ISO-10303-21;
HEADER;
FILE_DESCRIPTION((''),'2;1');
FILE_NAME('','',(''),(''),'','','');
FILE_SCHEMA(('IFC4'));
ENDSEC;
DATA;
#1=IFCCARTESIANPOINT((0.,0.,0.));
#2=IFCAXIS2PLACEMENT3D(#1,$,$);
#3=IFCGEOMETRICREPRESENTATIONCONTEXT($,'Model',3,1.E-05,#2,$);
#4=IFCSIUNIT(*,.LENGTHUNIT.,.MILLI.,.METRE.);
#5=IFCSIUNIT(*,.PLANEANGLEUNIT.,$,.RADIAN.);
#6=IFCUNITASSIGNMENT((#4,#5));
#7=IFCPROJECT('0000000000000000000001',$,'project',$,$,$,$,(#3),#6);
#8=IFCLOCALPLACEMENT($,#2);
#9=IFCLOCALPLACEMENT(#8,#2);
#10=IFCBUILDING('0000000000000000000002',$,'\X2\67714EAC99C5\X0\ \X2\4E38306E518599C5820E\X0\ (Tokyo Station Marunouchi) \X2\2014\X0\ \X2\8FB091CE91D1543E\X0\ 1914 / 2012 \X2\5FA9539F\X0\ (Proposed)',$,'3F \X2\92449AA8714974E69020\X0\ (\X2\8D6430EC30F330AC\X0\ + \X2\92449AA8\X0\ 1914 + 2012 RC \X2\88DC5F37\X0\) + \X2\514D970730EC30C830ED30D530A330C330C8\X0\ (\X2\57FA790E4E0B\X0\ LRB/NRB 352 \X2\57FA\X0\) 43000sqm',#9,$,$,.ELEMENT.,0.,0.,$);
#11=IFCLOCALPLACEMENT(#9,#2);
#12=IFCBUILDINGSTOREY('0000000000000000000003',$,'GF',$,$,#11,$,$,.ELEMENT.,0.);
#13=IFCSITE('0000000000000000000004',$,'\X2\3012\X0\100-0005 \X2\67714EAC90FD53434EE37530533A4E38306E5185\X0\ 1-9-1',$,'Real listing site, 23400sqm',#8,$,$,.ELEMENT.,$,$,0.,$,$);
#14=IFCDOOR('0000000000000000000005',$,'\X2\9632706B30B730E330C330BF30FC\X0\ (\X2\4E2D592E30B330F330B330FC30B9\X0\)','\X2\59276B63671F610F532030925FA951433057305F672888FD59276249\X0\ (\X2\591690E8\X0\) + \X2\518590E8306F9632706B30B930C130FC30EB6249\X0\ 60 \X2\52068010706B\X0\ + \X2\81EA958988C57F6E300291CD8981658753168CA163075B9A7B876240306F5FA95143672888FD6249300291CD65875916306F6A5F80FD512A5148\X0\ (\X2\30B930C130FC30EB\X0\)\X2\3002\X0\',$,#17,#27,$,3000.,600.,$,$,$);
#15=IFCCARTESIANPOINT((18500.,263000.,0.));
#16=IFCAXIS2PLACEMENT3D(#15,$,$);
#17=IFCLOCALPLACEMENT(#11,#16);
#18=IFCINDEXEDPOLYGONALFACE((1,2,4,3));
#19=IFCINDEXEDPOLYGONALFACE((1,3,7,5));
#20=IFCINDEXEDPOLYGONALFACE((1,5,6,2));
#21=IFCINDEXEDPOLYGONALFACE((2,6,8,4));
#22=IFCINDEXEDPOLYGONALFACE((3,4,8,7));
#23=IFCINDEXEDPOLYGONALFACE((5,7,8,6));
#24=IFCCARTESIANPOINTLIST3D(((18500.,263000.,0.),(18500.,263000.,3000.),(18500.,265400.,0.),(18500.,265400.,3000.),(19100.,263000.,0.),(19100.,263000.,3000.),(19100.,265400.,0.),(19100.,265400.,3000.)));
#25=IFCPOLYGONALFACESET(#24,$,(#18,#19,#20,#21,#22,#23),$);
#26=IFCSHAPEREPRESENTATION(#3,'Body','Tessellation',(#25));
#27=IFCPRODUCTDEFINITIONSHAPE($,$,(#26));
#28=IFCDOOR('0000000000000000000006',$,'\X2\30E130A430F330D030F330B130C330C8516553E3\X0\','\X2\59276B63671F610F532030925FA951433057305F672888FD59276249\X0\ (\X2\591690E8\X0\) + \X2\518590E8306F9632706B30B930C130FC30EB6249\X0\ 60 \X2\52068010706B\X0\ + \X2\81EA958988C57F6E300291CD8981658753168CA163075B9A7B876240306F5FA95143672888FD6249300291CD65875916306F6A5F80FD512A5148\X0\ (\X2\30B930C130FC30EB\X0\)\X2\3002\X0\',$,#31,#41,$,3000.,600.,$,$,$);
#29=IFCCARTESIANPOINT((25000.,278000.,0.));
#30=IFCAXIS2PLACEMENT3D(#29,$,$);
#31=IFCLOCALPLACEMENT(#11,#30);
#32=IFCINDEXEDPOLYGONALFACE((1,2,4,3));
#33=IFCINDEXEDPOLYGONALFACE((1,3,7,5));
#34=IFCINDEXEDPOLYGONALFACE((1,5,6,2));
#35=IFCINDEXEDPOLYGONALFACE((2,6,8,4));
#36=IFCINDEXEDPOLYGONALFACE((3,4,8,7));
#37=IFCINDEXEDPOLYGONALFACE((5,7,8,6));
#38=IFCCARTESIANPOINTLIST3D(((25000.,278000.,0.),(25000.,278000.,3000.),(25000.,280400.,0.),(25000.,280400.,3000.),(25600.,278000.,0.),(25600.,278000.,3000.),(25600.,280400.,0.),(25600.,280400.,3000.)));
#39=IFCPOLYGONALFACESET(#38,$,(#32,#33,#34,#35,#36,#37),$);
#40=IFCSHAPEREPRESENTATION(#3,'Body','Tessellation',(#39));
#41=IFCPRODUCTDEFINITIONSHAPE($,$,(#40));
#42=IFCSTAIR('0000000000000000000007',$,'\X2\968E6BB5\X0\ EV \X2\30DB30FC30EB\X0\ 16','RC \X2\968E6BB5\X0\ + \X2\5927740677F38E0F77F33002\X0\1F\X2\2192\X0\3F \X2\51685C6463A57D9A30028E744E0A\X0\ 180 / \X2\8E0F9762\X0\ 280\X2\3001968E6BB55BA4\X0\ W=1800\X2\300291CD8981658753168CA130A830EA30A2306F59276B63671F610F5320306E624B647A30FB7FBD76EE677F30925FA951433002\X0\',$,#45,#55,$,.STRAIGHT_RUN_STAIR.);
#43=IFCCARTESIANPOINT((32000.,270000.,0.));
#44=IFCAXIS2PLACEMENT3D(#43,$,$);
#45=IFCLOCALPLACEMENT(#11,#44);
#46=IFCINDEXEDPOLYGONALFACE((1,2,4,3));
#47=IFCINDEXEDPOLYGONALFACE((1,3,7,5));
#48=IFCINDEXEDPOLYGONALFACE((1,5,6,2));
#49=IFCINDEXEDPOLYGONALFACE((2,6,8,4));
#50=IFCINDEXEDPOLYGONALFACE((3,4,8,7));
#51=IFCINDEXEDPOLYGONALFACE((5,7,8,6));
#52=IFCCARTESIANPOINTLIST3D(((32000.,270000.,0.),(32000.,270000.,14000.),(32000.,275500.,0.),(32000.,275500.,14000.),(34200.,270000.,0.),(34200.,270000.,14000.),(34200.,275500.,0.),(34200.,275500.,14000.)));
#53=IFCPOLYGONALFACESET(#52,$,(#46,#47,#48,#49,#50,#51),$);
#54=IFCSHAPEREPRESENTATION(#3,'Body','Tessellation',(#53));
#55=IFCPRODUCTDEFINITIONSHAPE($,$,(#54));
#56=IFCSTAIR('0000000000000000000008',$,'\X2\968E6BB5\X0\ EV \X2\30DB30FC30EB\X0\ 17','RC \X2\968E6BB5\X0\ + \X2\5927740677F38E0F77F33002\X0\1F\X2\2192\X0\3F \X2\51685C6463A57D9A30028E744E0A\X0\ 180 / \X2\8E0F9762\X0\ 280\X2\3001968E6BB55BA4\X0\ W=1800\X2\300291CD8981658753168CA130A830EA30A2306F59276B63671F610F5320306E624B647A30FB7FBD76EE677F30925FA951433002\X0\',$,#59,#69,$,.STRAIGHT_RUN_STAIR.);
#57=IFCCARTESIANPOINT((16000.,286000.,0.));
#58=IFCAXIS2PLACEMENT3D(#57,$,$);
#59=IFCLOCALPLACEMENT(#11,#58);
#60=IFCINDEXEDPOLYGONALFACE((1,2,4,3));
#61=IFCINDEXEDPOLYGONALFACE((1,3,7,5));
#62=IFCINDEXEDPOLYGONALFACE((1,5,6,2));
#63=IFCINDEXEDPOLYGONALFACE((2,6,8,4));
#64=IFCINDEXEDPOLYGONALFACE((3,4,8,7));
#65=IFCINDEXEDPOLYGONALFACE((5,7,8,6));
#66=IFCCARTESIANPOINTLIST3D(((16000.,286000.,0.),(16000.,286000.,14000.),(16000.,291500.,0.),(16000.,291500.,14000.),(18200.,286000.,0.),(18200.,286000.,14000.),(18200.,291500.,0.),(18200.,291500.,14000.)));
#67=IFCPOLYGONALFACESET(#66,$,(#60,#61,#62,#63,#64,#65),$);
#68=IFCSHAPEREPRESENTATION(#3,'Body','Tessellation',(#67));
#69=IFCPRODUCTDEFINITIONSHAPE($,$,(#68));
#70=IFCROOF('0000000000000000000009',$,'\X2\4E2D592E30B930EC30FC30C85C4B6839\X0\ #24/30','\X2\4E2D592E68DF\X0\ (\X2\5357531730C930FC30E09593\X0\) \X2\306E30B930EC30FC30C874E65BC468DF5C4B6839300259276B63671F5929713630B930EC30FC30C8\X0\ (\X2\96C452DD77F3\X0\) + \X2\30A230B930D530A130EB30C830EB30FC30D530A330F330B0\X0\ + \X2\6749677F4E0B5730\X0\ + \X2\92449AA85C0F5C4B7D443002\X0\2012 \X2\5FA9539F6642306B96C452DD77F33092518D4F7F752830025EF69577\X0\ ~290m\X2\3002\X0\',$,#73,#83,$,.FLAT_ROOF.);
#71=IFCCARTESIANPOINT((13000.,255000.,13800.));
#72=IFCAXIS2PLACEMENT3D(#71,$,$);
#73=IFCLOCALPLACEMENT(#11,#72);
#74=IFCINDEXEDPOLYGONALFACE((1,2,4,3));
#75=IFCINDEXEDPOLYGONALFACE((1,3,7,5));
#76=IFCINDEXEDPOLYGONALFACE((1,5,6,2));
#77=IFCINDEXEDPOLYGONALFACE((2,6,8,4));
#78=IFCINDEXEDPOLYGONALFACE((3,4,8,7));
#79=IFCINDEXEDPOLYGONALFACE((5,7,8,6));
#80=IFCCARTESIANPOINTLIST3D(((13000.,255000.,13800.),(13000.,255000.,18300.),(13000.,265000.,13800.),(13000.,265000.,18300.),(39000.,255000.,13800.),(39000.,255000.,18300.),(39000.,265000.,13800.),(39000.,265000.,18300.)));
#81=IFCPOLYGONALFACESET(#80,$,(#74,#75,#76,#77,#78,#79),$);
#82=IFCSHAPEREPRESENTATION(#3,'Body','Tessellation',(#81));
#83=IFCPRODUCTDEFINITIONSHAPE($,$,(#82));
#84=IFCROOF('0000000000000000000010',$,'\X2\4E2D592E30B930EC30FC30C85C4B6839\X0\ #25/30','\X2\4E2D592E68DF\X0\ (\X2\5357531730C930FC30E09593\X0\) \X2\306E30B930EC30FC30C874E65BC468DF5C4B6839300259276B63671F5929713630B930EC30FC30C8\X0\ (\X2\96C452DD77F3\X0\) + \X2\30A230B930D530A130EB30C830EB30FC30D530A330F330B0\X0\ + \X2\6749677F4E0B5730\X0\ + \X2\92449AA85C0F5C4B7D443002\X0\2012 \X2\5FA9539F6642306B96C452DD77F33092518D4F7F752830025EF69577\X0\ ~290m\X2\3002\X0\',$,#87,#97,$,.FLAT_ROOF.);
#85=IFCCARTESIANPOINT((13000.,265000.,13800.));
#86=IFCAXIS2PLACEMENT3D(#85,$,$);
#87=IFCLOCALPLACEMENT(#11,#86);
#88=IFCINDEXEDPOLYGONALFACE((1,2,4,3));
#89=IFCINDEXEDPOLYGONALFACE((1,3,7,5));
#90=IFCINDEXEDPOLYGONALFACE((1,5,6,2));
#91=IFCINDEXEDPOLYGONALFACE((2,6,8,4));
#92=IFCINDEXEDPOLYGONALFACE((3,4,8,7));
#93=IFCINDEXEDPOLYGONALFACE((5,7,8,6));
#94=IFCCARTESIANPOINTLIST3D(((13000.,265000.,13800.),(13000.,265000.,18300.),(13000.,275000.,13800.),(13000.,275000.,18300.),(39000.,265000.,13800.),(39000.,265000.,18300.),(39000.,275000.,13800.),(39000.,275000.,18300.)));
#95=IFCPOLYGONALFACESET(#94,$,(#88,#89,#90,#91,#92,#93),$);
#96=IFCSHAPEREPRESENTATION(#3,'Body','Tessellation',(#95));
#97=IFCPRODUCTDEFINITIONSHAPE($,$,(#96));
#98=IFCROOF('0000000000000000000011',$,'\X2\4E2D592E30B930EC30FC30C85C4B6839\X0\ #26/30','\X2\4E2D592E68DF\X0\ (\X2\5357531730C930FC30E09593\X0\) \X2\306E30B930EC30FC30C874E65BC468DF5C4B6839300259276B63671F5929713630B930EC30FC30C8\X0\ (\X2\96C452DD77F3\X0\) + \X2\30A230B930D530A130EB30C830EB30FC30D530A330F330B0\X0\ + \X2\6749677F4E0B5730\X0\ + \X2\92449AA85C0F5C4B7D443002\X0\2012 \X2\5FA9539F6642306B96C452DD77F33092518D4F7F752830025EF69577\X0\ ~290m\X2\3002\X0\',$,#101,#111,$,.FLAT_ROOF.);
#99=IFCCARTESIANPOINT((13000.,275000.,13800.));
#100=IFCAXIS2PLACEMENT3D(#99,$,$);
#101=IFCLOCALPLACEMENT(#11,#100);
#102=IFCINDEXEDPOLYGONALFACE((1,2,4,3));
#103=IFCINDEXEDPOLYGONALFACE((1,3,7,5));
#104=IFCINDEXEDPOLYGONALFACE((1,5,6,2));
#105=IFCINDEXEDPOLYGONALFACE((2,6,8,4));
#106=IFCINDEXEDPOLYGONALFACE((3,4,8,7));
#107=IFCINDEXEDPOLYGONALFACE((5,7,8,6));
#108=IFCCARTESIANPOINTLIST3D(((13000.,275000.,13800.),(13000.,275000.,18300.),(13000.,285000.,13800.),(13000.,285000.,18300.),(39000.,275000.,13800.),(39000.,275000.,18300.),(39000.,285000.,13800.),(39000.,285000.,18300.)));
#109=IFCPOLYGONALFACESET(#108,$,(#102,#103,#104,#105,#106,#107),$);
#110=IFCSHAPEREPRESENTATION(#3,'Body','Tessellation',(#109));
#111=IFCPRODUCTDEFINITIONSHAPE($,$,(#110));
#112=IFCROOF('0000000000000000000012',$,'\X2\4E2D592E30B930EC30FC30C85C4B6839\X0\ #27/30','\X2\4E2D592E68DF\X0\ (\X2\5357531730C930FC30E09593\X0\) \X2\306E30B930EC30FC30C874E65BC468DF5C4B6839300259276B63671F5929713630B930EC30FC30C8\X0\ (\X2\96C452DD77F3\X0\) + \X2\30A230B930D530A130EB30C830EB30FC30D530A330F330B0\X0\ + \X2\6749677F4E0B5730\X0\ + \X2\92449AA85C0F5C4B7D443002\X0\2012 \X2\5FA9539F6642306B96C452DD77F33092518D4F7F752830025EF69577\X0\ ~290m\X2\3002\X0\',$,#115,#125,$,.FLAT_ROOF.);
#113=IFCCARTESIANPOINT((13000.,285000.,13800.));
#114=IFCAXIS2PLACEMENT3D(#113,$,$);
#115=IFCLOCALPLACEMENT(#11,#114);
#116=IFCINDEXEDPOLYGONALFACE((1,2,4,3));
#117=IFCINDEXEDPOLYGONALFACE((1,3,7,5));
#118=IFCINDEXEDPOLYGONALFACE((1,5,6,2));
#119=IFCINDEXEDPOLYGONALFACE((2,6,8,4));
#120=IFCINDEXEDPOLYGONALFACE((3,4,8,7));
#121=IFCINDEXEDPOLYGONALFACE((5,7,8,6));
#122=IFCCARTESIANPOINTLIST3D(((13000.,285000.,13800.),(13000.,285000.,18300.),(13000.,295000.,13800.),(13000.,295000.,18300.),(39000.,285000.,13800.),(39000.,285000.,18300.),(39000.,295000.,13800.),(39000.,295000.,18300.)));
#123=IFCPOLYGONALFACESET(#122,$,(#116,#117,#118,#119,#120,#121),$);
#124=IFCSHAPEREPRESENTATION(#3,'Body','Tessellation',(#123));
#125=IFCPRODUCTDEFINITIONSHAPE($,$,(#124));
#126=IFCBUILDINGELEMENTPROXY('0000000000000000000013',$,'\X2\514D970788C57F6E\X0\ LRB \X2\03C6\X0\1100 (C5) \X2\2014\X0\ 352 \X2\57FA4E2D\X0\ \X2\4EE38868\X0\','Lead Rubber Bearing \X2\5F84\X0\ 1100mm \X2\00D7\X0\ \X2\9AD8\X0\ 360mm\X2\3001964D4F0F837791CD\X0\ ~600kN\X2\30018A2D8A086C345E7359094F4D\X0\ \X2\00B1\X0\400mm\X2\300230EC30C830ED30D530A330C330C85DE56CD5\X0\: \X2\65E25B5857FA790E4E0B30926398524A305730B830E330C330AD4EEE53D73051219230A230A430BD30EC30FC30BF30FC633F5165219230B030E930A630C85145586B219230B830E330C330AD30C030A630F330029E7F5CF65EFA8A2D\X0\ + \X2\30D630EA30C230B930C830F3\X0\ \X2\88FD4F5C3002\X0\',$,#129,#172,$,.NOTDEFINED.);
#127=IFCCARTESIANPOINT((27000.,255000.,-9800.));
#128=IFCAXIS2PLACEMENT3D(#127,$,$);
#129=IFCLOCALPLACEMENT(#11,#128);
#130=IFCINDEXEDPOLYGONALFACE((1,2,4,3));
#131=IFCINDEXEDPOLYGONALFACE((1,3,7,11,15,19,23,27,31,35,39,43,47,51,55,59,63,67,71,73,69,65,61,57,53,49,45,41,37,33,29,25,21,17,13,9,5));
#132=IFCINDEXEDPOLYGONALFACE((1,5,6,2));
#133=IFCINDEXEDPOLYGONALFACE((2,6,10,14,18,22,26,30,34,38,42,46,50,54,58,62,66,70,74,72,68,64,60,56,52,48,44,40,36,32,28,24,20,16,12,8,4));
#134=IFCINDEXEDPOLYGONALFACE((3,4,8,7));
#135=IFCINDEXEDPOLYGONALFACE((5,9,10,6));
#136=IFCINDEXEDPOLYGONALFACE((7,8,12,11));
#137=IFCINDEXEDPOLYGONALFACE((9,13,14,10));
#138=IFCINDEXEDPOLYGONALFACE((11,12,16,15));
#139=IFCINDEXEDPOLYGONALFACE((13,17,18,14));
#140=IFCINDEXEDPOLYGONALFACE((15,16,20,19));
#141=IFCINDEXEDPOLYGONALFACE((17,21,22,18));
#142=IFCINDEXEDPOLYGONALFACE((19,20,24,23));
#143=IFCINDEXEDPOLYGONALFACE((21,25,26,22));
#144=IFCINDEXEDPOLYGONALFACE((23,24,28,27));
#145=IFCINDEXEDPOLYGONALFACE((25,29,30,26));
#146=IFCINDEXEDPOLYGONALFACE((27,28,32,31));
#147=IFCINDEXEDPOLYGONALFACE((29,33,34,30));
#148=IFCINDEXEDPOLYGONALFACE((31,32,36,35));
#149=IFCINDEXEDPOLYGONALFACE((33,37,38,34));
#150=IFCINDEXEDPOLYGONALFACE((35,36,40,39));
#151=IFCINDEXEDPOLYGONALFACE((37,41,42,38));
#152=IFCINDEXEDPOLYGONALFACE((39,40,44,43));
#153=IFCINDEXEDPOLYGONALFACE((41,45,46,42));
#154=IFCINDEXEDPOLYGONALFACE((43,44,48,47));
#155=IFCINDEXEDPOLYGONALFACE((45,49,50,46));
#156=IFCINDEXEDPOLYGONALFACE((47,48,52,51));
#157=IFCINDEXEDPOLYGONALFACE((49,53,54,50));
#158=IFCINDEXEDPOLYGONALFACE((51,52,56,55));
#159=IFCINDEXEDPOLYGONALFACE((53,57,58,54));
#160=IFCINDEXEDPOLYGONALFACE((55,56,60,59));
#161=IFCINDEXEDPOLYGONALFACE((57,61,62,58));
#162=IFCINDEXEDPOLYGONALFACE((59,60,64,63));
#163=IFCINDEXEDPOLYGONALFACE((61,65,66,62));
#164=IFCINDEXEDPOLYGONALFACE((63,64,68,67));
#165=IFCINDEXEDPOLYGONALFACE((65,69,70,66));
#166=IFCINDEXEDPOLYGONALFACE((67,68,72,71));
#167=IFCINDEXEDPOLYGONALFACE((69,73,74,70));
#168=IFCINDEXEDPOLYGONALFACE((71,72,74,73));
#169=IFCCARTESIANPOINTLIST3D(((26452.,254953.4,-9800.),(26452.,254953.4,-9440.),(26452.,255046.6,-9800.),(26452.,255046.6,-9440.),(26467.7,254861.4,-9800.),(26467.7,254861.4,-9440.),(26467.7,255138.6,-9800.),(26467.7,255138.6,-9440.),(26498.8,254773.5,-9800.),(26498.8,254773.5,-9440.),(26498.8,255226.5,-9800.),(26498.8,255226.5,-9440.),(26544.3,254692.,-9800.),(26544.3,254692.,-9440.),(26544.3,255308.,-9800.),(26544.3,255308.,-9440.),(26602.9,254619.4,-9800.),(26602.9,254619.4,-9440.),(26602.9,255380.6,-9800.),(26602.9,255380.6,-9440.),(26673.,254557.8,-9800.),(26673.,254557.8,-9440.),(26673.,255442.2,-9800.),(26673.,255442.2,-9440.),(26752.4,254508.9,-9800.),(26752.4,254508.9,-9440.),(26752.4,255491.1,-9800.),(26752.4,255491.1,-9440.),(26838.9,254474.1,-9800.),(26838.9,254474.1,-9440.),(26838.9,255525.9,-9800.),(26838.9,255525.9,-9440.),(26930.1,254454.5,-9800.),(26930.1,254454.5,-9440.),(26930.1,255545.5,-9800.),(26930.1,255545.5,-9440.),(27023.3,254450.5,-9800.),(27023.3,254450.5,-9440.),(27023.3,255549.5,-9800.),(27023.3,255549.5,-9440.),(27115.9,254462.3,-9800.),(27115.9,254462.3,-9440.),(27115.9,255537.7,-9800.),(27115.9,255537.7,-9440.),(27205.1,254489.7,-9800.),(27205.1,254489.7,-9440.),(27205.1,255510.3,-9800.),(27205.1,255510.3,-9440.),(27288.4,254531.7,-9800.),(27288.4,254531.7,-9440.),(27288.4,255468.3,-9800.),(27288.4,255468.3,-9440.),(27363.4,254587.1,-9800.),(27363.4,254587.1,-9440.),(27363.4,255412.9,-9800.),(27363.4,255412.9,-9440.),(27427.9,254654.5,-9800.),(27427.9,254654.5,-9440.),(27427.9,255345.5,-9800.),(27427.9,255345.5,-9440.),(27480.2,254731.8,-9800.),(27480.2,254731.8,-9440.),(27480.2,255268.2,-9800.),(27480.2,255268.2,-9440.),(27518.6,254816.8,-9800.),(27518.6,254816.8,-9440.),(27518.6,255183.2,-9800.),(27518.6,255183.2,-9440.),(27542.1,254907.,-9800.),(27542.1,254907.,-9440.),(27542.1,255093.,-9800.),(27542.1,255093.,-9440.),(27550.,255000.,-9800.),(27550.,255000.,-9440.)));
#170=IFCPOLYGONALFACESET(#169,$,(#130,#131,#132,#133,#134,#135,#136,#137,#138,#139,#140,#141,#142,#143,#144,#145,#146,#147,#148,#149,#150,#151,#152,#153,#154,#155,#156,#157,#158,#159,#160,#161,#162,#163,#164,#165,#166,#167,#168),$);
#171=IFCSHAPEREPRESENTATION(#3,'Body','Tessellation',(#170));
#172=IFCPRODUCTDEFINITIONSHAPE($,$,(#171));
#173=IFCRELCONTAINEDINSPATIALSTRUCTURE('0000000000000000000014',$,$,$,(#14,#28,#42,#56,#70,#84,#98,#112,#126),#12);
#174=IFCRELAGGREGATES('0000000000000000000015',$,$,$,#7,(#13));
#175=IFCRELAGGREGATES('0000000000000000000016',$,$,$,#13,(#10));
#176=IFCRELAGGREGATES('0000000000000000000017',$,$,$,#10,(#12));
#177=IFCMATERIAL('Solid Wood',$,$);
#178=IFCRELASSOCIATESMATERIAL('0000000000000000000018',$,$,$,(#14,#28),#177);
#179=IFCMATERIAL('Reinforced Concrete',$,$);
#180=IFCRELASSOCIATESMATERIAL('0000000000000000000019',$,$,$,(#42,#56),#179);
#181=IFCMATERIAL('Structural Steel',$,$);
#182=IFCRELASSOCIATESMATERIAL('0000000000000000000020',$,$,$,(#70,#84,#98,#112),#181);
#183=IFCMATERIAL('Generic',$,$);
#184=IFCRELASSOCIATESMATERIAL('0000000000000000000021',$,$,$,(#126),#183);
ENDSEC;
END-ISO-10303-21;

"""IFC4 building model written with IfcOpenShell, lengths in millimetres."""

from ifc_helpers import new_model, si_unit, frame, frame_2d, origin, origin_2d, place, context, project, spatial, rectangle, circle, extrude, material, element, save


model = new_model("IFC4")

# Units and contexts
model_context = context("Model", 3, precision=1e-05, world=origin())
ifc_project = project(units=[si_unit("LENGTHUNIT", "METRE", prefix="MILLI"), si_unit("PLANEANGLEUNIT", "RADIAN")], contexts=[model_context])

# Site, building, storey
site_placement = place(None, origin())
site = spatial("IfcSite", under=ifc_project, at=site_placement, Name="〒100-0005 東京都千代田区丸の内 1-9-1", ObjectType="Real listing site, 23400sqm", CompositionType="ELEMENT", RefElevation=0.0)
building_placement = place(site_placement, origin())
building = spatial("IfcBuilding", under=site, at=building_placement, Name="東京駅 丸の内駅舎 (Tokyo Station Marunouchi) — 辰野金吾 1914 / 2012 復原 (Proposed)", ObjectType="3F 鉄骨煉瓦造 (赤レンガ + 鉄骨 1914 + 2012 RC 補強) + 免震レトロフィット (基礎下 LRB/NRB 352 基) 43000sqm", CompositionType="ELEMENT", ElevationOfRefHeight=0.0, ElevationOfTerrain=0.0)
storey_placement = place(building_placement, origin())
storey = spatial("IfcBuildingStorey", under=building, at=storey_placement, Name="GF", CompositionType="ELEMENT", Elevation=0.0)

# Shared definitions
ifc_material_1 = material(Name="Reinforced Concrete")

# Shared definitions
ifc_material_2 = material(Name="Structural Steel")

# Shared definitions
ifc_material_3 = material(Name="Solid Wood")

# Doors
door_1_placement = place(storey_placement, frame((18500.0, 263000.0, 0.0)))
element("IfcDoor", 1, at=door_1_placement, inside=storey, material=ifc_material_3, Name="防火シャッター (中央コンコース)", Description="大正期意匠を復元した木製大扉 (外部) + 内部は防火スチール扉 60 分耐火 + 自閉装置。重要文化財指定箇所は復元木製扉。重文外は機能優先 (スチール)。", OverallHeight=3000.0, OverallWidth=600.0, context=model_context, shape_type="SweptSolid", body=[
    extrude(rectangle(XDim=600.0, YDim=2400.0, at=frame_2d((300.0, 1200.0))), frame((18500.0, 263000.0, 0.0)), (0.0, 0.0, 1.0), 3000.0),
])
door_2_placement = place(storey_placement, frame((25000.0, 278000.0, 0.0)))
element("IfcDoor", 2, at=door_2_placement, inside=storey, material=ifc_material_3, Name="メインバンケット入口", Description="大正期意匠を復元した木製大扉 (外部) + 内部は防火スチール扉 60 分耐火 + 自閉装置。重要文化財指定箇所は復元木製扉。重文外は機能優先 (スチール)。", OverallHeight=3000.0, OverallWidth=600.0, context=model_context, shape_type="SweptSolid", body=[
    extrude(rectangle(XDim=600.0, YDim=2400.0, at=frame_2d((300.0, 1200.0))), frame((25000.0, 278000.0, 0.0)), (0.0, 0.0, 1.0), 3000.0),
])

# Stairs
stair_1_placement = place(storey_placement, frame((32000.0, 270000.0, 0.0)))
element("IfcStair", 3, at=stair_1_placement, inside=storey, material=ifc_material_1, Name="階段 EV ホール 16", Description="RC 階段 + 大理石踏石。1F→3F 全層接続。蹴上 180 / 踏面 280、階段室 W=1800。重要文化財エリアは大正期意匠の手摺・羽目板を復元。", PredefinedType="STRAIGHT_RUN_STAIR", context=model_context, shape_type="SweptSolid", body=[
    extrude(rectangle(XDim=2200.0, YDim=5500.0, at=frame_2d((1100.0, 2750.0))), frame((32000.0, 270000.0, 0.0)), (0.0, 0.0, 1.0), 14000.0),
])
stair_2_placement = place(storey_placement, frame((16000.0, 286000.0, 0.0)))
element("IfcStair", 4, at=stair_2_placement, inside=storey, material=ifc_material_1, Name="階段 EV ホール 17", Description="RC 階段 + 大理石踏石。1F→3F 全層接続。蹴上 180 / 踏面 280、階段室 W=1800。重要文化財エリアは大正期意匠の手摺・羽目板を復元。", PredefinedType="STRAIGHT_RUN_STAIR", context=model_context, shape_type="SweptSolid", body=[
    extrude(rectangle(XDim=2200.0, YDim=5500.0, at=frame_2d((1100.0, 2750.0))), frame((16000.0, 286000.0, 0.0)), (0.0, 0.0, 1.0), 14000.0),
])

# Roofs
roof_1_placement = place(storey_placement, frame((13000.0, 255000.0, 13800.0)))
element("IfcRoof", 5, at=roof_1_placement, inside=storey, material=ifc_material_2, Name="中央スレート屋根 #24/30", Description="中央棟 (南北ドーム間) のスレート瓦寄棟屋根。大正期天然スレート (雄勝石) + アスファルトルーフィング + 杉板下地 + 鉄骨小屋組。2012 復原時に雄勝石を再使用。延長 ~290m。", PredefinedType="FLAT_ROOF", context=model_context, shape_type="SweptSolid", body=[
    extrude(rectangle(XDim=26000.0, YDim=10000.0, at=frame_2d((13000.0, 5000.0))), frame((13000.0, 255000.0, 13800.0)), (0.0, 0.0, 1.0), 4500.0),
])
roof_2_placement = place(storey_placement, frame((13000.0, 265000.0, 13800.0)))
element("IfcRoof", 6, at=roof_2_placement, inside=storey, material=ifc_material_2, Name="中央スレート屋根 #25/30", Description="中央棟 (南北ドーム間) のスレート瓦寄棟屋根。大正期天然スレート (雄勝石) + アスファルトルーフィング + 杉板下地 + 鉄骨小屋組。2012 復原時に雄勝石を再使用。延長 ~290m。", PredefinedType="FLAT_ROOF", context=model_context, shape_type="SweptSolid", body=[
    extrude(rectangle(XDim=26000.0, YDim=10000.0, at=frame_2d((13000.0, 5000.0))), frame((13000.0, 265000.0, 13800.0)), (0.0, 0.0, 1.0), 4500.0),
])
roof_3_placement = place(storey_placement, frame((13000.0, 275000.0, 13800.0)))
element("IfcRoof", 7, at=roof_3_placement, inside=storey, material=ifc_material_2, Name="中央スレート屋根 #26/30", Description="中央棟 (南北ドーム間) のスレート瓦寄棟屋根。大正期天然スレート (雄勝石) + アスファルトルーフィング + 杉板下地 + 鉄骨小屋組。2012 復原時に雄勝石を再使用。延長 ~290m。", PredefinedType="FLAT_ROOF", context=model_context, shape_type="SweptSolid", body=[
    extrude(rectangle(XDim=26000.0, YDim=10000.0, at=frame_2d((13000.0, 5000.0))), frame((13000.0, 275000.0, 13800.0)), (0.0, 0.0, 1.0), 4500.0),
])
roof_4_placement = place(storey_placement, frame((13000.0, 285000.0, 13800.0)))
element("IfcRoof", 8, at=roof_4_placement, inside=storey, material=ifc_material_2, Name="中央スレート屋根 #27/30", Description="中央棟 (南北ドーム間) のスレート瓦寄棟屋根。大正期天然スレート (雄勝石) + アスファルトルーフィング + 杉板下地 + 鉄骨小屋組。2012 復原時に雄勝石を再使用。延長 ~290m。", PredefinedType="FLAT_ROOF", context=model_context, shape_type="SweptSolid", body=[
    extrude(rectangle(XDim=26000.0, YDim=10000.0, at=frame_2d((13000.0, 5000.0))), frame((13000.0, 285000.0, 13800.0)), (0.0, 0.0, 1.0), 4500.0),
])

# Building element proxy
ifc_material_4 = material(Name="Generic")
proxy_1_placement = place(storey_placement, frame((27000.0, 255000.0, -9800.0)))
element("IfcBuildingElementProxy", 9, at=proxy_1_placement, inside=storey, material=ifc_material_4, Name="免震装置 LRB φ1100 (C5) — 352 基中 代表", Description="Lead Rubber Bearing 径 1100mm × 高 360mm、降伏荷重 ~600kN、設計水平変位 ±400mm。レトロフィット工法: 既存基礎下を掘削しジャッキ仮受け→アイソレーター挿入→グラウト充填→ジャッキダウン。鹿島建設 + ブリヂストン 製作。", PredefinedType="NOTDEFINED", context=model_context, shape_type="SweptSolid", body=[
    extrude(circle(Radius=550.0, at=origin_2d()), frame((27000.0, 255000.0, -9800.0)), (0.0, 0.0, 1.0), 360.0),
])

save(model, "model.ifc")
